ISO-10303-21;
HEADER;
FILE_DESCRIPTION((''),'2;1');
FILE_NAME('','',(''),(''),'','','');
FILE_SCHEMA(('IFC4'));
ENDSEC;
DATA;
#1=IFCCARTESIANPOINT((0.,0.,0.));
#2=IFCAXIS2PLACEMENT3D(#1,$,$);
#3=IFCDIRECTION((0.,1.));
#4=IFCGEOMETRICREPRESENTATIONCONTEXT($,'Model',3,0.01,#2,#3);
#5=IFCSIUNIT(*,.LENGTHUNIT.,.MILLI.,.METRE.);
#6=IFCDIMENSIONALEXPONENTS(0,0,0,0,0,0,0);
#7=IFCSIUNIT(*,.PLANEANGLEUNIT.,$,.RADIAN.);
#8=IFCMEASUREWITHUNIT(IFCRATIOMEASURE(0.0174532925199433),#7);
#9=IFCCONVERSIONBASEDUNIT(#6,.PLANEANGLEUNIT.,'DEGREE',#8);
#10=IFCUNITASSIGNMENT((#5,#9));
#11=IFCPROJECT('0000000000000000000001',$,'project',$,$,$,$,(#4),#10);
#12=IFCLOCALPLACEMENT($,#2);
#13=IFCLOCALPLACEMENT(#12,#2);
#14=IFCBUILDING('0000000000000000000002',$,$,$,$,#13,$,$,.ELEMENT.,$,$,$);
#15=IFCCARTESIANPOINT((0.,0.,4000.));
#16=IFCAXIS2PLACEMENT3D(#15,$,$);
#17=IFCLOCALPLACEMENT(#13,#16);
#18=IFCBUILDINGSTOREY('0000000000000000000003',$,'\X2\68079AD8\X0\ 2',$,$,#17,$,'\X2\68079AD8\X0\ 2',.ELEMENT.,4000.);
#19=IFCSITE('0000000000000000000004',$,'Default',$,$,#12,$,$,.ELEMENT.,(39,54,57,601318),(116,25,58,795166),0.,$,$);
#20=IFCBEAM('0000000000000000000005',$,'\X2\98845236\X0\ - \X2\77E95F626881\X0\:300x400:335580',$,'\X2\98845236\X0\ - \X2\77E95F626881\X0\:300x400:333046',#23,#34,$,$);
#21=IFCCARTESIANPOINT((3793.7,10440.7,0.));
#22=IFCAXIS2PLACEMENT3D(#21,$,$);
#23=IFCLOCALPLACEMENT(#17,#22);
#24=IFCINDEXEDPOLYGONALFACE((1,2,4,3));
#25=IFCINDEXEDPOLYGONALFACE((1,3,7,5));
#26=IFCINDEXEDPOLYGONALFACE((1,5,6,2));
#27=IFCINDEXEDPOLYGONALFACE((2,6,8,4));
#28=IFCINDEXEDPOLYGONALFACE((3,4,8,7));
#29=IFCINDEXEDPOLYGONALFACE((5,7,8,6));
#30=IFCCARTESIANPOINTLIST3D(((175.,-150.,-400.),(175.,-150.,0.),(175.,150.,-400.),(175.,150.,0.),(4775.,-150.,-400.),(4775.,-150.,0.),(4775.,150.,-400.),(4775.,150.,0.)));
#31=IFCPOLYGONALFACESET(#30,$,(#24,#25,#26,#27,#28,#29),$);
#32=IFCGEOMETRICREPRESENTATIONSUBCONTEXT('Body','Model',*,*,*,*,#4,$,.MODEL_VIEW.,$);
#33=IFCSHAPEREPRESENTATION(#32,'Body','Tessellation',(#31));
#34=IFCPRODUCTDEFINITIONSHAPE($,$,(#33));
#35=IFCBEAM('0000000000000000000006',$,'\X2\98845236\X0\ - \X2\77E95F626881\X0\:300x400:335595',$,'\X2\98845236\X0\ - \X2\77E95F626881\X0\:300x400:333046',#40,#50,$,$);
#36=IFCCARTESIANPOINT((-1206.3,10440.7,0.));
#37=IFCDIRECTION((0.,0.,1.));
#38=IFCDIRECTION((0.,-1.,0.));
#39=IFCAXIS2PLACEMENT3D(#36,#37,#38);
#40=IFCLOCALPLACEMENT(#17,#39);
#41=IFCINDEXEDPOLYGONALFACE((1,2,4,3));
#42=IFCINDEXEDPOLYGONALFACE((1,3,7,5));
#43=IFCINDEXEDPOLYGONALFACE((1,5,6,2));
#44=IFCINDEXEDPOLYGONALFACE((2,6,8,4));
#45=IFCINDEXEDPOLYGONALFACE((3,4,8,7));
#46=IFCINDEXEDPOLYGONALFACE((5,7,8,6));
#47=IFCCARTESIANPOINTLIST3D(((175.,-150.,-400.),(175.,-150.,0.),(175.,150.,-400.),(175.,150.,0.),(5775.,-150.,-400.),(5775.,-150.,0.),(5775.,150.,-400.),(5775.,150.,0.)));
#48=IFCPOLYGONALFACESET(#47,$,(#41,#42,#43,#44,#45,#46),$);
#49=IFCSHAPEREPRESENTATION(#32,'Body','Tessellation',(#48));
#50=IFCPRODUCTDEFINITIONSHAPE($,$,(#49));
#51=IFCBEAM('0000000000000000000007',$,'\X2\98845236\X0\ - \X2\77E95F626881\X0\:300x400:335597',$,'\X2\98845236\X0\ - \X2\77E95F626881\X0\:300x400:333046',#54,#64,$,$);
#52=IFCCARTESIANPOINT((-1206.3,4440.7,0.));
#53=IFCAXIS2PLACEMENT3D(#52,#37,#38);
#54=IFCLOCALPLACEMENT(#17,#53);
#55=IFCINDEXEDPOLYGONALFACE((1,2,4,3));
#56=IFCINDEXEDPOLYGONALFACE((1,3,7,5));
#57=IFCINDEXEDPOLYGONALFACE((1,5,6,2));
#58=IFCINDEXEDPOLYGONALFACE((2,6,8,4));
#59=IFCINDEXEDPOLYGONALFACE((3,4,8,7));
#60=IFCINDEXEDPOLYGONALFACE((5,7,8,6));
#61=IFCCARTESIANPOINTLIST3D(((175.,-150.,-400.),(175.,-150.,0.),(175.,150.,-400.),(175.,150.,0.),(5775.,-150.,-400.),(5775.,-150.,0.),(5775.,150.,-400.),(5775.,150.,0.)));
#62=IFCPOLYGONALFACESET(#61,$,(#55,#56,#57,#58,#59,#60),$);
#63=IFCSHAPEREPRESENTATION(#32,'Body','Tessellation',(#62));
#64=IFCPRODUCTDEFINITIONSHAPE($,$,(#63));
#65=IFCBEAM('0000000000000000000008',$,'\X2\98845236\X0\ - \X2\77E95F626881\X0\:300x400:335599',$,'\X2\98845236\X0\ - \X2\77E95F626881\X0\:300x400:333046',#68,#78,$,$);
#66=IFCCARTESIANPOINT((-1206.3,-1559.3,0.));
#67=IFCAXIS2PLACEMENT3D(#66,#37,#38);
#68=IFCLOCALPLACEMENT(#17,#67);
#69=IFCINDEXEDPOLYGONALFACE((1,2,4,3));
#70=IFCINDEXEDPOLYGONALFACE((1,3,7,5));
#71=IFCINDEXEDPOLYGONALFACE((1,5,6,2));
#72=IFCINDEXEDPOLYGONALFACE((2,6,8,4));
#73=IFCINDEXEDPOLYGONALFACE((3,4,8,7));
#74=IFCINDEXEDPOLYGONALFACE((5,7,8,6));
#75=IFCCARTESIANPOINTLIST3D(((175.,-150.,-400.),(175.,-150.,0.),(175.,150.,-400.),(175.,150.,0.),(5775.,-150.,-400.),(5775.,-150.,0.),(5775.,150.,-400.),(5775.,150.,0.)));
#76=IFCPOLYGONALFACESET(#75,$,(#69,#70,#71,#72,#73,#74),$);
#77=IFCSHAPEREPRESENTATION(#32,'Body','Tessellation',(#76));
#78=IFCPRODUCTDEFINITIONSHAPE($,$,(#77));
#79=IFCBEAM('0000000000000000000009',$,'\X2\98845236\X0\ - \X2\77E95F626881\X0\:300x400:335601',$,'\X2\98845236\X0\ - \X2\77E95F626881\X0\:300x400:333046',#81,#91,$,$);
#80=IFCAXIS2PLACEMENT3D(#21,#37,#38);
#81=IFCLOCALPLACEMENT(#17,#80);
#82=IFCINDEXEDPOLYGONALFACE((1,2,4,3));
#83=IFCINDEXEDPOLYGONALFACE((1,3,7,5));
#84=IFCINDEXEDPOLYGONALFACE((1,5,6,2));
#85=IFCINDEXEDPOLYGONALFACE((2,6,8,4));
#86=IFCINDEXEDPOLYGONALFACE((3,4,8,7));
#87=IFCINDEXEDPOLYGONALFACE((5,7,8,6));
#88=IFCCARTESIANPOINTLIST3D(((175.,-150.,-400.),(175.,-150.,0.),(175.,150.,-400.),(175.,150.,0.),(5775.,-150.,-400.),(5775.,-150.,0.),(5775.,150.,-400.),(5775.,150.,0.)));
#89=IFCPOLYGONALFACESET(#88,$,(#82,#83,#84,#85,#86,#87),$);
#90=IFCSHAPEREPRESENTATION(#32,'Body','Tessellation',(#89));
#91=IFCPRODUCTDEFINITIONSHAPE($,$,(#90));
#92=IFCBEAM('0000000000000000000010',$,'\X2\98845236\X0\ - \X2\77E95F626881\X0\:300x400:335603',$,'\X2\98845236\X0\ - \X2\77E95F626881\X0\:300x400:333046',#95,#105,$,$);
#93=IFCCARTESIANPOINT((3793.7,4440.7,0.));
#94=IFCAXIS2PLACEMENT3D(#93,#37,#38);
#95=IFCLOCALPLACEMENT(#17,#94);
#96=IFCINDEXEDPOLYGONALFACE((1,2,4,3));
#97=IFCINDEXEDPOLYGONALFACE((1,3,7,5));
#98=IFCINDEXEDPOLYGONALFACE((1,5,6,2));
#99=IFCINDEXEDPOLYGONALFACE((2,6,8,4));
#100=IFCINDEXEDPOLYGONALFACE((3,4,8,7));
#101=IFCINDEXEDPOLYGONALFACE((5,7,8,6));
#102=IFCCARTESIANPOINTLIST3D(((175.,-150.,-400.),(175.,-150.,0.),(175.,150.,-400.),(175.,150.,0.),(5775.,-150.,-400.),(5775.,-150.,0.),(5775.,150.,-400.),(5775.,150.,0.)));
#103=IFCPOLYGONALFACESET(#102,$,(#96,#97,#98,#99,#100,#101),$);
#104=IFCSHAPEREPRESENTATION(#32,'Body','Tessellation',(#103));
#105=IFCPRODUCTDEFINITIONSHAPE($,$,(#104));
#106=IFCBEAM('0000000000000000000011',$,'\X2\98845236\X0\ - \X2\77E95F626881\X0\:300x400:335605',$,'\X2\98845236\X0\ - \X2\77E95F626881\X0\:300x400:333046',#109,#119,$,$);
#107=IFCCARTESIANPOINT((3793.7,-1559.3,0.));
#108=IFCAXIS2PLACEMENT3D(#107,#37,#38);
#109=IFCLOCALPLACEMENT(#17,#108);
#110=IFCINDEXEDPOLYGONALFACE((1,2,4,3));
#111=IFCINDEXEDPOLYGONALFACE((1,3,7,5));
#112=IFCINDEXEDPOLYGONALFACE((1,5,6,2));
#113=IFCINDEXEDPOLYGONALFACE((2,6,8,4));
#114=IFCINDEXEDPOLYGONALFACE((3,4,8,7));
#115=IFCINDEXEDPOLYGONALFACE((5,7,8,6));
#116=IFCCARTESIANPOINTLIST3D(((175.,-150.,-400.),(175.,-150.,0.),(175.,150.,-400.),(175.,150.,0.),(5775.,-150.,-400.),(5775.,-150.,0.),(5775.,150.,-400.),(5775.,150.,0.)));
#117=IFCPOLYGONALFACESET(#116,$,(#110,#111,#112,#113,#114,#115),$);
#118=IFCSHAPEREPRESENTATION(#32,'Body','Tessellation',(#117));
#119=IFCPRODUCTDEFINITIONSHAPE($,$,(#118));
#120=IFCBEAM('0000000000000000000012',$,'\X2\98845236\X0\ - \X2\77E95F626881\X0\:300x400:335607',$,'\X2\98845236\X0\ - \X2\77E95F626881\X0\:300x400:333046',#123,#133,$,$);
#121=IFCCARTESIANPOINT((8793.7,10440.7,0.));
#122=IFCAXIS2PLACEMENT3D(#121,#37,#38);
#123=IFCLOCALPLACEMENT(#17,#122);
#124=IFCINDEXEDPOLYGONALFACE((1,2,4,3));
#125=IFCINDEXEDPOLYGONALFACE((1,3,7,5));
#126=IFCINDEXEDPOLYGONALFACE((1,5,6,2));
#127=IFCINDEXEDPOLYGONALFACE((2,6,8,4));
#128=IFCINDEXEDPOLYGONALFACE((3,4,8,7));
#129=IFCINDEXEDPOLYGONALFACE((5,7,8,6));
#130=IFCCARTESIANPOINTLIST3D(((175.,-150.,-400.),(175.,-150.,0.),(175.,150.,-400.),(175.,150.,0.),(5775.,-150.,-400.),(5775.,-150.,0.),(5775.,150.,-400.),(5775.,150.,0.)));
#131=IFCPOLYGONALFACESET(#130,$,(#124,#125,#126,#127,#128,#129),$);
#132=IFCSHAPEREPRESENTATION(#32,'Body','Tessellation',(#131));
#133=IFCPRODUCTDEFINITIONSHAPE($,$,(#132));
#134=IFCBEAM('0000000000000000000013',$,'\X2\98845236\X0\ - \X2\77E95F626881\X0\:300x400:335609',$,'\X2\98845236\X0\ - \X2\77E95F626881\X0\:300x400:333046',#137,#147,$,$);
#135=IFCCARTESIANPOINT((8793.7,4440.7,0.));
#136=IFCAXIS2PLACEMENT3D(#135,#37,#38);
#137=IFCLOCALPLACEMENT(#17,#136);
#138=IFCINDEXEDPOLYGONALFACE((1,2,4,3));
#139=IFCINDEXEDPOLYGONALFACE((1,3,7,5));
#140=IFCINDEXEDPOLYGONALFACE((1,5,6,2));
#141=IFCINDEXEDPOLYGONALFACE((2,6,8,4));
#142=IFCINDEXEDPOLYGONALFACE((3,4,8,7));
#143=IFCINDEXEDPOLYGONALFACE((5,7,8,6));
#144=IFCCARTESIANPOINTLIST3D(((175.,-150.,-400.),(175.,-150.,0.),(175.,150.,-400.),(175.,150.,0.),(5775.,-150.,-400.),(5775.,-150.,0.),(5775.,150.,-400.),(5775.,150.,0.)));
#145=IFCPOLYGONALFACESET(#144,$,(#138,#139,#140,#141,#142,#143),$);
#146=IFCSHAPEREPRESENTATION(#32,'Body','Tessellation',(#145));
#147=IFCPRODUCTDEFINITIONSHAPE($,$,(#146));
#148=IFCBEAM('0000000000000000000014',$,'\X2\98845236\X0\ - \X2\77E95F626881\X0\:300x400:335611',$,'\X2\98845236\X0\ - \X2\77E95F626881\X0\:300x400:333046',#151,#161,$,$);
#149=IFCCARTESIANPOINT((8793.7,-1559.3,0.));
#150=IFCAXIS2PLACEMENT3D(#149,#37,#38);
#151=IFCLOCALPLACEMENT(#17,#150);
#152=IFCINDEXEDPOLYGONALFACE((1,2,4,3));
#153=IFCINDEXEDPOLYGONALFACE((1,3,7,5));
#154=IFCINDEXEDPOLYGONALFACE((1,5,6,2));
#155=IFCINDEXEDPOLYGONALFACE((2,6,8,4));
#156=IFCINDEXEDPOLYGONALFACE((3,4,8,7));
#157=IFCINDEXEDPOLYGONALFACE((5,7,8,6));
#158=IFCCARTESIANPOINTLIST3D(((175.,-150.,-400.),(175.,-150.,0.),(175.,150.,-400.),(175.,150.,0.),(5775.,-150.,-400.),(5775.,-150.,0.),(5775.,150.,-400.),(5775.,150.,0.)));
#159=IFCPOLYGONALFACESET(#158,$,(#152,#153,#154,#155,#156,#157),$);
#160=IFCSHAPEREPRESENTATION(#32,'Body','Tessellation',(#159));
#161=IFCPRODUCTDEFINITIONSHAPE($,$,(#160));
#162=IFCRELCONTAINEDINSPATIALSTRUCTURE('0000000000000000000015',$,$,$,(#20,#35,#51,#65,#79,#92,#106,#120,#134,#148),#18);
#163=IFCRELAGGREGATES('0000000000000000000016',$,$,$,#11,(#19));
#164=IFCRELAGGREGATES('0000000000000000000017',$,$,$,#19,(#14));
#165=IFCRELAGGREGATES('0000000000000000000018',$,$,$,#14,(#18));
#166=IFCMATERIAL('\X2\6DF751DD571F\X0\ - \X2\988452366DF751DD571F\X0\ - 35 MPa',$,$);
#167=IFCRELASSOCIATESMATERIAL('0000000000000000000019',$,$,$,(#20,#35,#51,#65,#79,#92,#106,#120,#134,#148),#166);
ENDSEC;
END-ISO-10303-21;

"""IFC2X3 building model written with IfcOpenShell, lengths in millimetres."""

from ifc_helpers import new_model, entity, si_unit, converted_unit, direction, frame, frame_2d, origin, place, context, subcontext, project, spatial, rectangle, extrude, material, element, save


model = new_model("IFC2X3")

# Units and contexts
model_context = context("Model", 3, precision=0.01, world=origin(), true_north=direction((0.0, 1.0)))
body_context = subcontext(model_context, "Body", "Model", "MODEL_VIEW")
ifc_project = project(units=[si_unit("LENGTHUNIT", "METRE", prefix="MILLI"), converted_unit("PLANEANGLEUNIT", "DEGREE", entity("IfcRatioMeasure", 0.0174532925199433), si_unit("PLANEANGLEUNIT", "RADIAN"), dimensions=[0, 0, 0, 0, 0, 0, 0])], contexts=[model_context])

# Site, building, storey
site_placement = place(None, origin())
site = spatial("IfcSite", under=ifc_project, at=site_placement, Name="Default", CompositionType="ELEMENT", RefLatitude=(39, 54, 57, 601318), RefLongitude=(116, 25, 58, 795166), RefElevation=0.0)
building_placement = place(site_placement, origin())
building = spatial("IfcBuilding", under=site, at=building_placement, CompositionType="ELEMENT")
storey_placement = place(building_placement, frame((0.0, 0.0, 4000.0)))
storey = spatial("IfcBuildingStorey", under=building, at=storey_placement, Name="标高 2", LongName="标高 2", CompositionType="ELEMENT", Elevation=4000.0)

# Shared definitions
ifc_material_1 = material(Name="混凝土 - 预制混凝土 - 35 MPa")

# Beams
beam_1_placement = place(storey_placement, frame((3793.7, 10440.7, 0.0)))
element("IfcBeam", 1, at=beam_1_placement, inside=storey, material=ifc_material_1, Name="预制 - 矩形梁:300x400:335580", ObjectType="预制 - 矩形梁:300x400:333046", context=body_context, shape_type="SweptSolid", body=[
    extrude(rectangle(XDim=400.0, YDim=300.0, at=frame_2d((0.0, 0.0), x_axis=(1.0, 0.0))), frame((175.0, 0.0, -200.0), z_axis=(1.0, 0.0, 0.0), x_axis=(0.0, 0.0, -1.0)), (0.0, 0.0, 1.0), 4600.0),
])
beam_2_placement = place(storey_placement, frame((-1206.3, 10440.7, 0.0), z_axis=(0.0, 0.0, 1.0), x_axis=(0.0, -1.0, 0.0)))
element("IfcBeam", 2, at=beam_2_placement, inside=storey, material=ifc_material_1, Name="预制 - 矩形梁:300x400:335595", ObjectType="预制 - 矩形梁:300x400:333046", context=body_context, shape_type="SweptSolid", body=[
    extrude(rectangle(XDim=400.0, YDim=300.0, at=frame_2d((0.0, 0.0), x_axis=(1.0, 0.0))), frame((175.0, 0.0, -200.0), z_axis=(1.0, 0.0, 0.0), x_axis=(0.0, 0.0, -1.0)), (0.0, 0.0, 1.0), 5600.0),
])
beam_3_placement = place(storey_placement, frame((-1206.3, 4440.7, 0.0), z_axis=(0.0, 0.0, 1.0), x_axis=(0.0, -1.0, 0.0)))
element("IfcBeam", 3, at=beam_3_placement, inside=storey, material=ifc_material_1, Name="预制 - 矩形梁:300x400:335597", ObjectType="预制 - 矩形梁:300x400:333046", context=body_context, shape_type="SweptSolid", body=[
    extrude(rectangle(XDim=400.0, YDim=300.0, at=frame_2d((0.0, 0.0), x_axis=(1.0, 0.0))), frame((175.0, 0.0, -200.0), z_axis=(1.0, 0.0, 0.0), x_axis=(0.0, 0.0, -1.0)), (0.0, 0.0, 1.0), 5600.0),
])
beam_4_placement = place(storey_placement, frame((-1206.3, -1559.3, 0.0), z_axis=(0.0, 0.0, 1.0), x_axis=(0.0, -1.0, 0.0)))
element("IfcBeam", 4, at=beam_4_placement, inside=storey, material=ifc_material_1, Name="预制 - 矩形梁:300x400:335599", ObjectType="预制 - 矩形梁:300x400:333046", context=body_context, shape_type="SweptSolid", body=[
    extrude(rectangle(XDim=400.0, YDim=300.0, at=frame_2d((0.0, 0.0), x_axis=(1.0, 0.0))), frame((175.0, 0.0, -200.0), z_axis=(1.0, 0.0, 0.0), x_axis=(0.0, 0.0, -1.0)), (0.0, 0.0, 1.0), 5600.0),
])
beam_5_placement = place(storey_placement, frame((3793.7, 10440.7, 0.0), z_axis=(0.0, 0.0, 1.0), x_axis=(0.0, -1.0, 0.0)))
element("IfcBeam", 5, at=beam_5_placement, inside=storey, material=ifc_material_1, Name="预制 - 矩形梁:300x400:335601", ObjectType="预制 - 矩形梁:300x400:333046", context=body_context, shape_type="SweptSolid", body=[
    extrude(rectangle(XDim=400.0, YDim=300.0, at=frame_2d((0.0, 0.0), x_axis=(1.0, 0.0))), frame((175.0, 0.0, -200.0), z_axis=(1.0, 0.0, 0.0), x_axis=(0.0, 0.0, -1.0)), (0.0, 0.0, 1.0), 5600.0),
])
beam_6_placement = place(storey_placement, frame((3793.7, 4440.7, 0.0), z_axis=(0.0, 0.0, 1.0), x_axis=(0.0, -1.0, 0.0)))
element("IfcBeam", 6, at=beam_6_placement, inside=storey, material=ifc_material_1, Name="预制 - 矩形梁:300x400:335603", ObjectType="预制 - 矩形梁:300x400:333046", context=body_context, shape_type="SweptSolid", body=[
    extrude(rectangle(XDim=400.0, YDim=300.0, at=frame_2d((0.0, 0.0), x_axis=(1.0, 0.0))), frame((175.0, 0.0, -200.0), z_axis=(1.0, 0.0, 0.0), x_axis=(0.0, 0.0, -1.0)), (0.0, 0.0, 1.0), 5600.0),
])
beam_7_placement = place(storey_placement, frame((3793.7, -1559.3, 0.0), z_axis=(0.0, 0.0, 1.0), x_axis=(0.0, -1.0, 0.0)))
element("IfcBeam", 7, at=beam_7_placement, inside=storey, material=ifc_material_1, Name="预制 - 矩形梁:300x400:335605", ObjectType="预制 - 矩形梁:300x400:333046", context=body_context, shape_type="SweptSolid", body=[
    extrude(rectangle(XDim=400.0, YDim=300.0, at=frame_2d((0.0, 0.0), x_axis=(1.0, 0.0))), frame((175.0, 0.0, -200.0), z_axis=(1.0, 0.0, 0.0), x_axis=(0.0, 0.0, -1.0)), (0.0, 0.0, 1.0), 5600.0),
])
for number, where, z_axis, x_axis, name in (
    (8, (8793.7, 10440.7, 0.0), (0.0, 0.0, 1.0), (0.0, -1.0, 0.0), "预制 - 矩形梁:300x400:335607"),
    (9, (8793.7, 4440.7, 0.0), (0.0, 0.0, 1.0), (0.0, -1.0, 0.0), "预制 - 矩形梁:300x400:335609"),
    (10, (8793.7, -1559.3, 0.0), (0.0, 0.0, 1.0), (0.0, -1.0, 0.0), "预制 - 矩形梁:300x400:335611"),
):
    element("IfcBeam", number, at=place(storey_placement, frame(where, z_axis=z_axis, x_axis=x_axis)), inside=storey, material=ifc_material_1, Name=name, ObjectType="预制 - 矩形梁:300x400:333046", context=body_context, shape_type="SweptSolid", body=[
        extrude(rectangle(XDim=400.0, YDim=300.0, at=frame_2d((0.0, 0.0), x_axis=(1.0, 0.0))), frame((175.0, 0.0, -200.0), z_axis=(1.0, 0.0, 0.0), x_axis=(0.0, 0.0, -1.0)), (0.0, 0.0, 1.0), 5600.0),
    ])

save(model, "model.ifc")
